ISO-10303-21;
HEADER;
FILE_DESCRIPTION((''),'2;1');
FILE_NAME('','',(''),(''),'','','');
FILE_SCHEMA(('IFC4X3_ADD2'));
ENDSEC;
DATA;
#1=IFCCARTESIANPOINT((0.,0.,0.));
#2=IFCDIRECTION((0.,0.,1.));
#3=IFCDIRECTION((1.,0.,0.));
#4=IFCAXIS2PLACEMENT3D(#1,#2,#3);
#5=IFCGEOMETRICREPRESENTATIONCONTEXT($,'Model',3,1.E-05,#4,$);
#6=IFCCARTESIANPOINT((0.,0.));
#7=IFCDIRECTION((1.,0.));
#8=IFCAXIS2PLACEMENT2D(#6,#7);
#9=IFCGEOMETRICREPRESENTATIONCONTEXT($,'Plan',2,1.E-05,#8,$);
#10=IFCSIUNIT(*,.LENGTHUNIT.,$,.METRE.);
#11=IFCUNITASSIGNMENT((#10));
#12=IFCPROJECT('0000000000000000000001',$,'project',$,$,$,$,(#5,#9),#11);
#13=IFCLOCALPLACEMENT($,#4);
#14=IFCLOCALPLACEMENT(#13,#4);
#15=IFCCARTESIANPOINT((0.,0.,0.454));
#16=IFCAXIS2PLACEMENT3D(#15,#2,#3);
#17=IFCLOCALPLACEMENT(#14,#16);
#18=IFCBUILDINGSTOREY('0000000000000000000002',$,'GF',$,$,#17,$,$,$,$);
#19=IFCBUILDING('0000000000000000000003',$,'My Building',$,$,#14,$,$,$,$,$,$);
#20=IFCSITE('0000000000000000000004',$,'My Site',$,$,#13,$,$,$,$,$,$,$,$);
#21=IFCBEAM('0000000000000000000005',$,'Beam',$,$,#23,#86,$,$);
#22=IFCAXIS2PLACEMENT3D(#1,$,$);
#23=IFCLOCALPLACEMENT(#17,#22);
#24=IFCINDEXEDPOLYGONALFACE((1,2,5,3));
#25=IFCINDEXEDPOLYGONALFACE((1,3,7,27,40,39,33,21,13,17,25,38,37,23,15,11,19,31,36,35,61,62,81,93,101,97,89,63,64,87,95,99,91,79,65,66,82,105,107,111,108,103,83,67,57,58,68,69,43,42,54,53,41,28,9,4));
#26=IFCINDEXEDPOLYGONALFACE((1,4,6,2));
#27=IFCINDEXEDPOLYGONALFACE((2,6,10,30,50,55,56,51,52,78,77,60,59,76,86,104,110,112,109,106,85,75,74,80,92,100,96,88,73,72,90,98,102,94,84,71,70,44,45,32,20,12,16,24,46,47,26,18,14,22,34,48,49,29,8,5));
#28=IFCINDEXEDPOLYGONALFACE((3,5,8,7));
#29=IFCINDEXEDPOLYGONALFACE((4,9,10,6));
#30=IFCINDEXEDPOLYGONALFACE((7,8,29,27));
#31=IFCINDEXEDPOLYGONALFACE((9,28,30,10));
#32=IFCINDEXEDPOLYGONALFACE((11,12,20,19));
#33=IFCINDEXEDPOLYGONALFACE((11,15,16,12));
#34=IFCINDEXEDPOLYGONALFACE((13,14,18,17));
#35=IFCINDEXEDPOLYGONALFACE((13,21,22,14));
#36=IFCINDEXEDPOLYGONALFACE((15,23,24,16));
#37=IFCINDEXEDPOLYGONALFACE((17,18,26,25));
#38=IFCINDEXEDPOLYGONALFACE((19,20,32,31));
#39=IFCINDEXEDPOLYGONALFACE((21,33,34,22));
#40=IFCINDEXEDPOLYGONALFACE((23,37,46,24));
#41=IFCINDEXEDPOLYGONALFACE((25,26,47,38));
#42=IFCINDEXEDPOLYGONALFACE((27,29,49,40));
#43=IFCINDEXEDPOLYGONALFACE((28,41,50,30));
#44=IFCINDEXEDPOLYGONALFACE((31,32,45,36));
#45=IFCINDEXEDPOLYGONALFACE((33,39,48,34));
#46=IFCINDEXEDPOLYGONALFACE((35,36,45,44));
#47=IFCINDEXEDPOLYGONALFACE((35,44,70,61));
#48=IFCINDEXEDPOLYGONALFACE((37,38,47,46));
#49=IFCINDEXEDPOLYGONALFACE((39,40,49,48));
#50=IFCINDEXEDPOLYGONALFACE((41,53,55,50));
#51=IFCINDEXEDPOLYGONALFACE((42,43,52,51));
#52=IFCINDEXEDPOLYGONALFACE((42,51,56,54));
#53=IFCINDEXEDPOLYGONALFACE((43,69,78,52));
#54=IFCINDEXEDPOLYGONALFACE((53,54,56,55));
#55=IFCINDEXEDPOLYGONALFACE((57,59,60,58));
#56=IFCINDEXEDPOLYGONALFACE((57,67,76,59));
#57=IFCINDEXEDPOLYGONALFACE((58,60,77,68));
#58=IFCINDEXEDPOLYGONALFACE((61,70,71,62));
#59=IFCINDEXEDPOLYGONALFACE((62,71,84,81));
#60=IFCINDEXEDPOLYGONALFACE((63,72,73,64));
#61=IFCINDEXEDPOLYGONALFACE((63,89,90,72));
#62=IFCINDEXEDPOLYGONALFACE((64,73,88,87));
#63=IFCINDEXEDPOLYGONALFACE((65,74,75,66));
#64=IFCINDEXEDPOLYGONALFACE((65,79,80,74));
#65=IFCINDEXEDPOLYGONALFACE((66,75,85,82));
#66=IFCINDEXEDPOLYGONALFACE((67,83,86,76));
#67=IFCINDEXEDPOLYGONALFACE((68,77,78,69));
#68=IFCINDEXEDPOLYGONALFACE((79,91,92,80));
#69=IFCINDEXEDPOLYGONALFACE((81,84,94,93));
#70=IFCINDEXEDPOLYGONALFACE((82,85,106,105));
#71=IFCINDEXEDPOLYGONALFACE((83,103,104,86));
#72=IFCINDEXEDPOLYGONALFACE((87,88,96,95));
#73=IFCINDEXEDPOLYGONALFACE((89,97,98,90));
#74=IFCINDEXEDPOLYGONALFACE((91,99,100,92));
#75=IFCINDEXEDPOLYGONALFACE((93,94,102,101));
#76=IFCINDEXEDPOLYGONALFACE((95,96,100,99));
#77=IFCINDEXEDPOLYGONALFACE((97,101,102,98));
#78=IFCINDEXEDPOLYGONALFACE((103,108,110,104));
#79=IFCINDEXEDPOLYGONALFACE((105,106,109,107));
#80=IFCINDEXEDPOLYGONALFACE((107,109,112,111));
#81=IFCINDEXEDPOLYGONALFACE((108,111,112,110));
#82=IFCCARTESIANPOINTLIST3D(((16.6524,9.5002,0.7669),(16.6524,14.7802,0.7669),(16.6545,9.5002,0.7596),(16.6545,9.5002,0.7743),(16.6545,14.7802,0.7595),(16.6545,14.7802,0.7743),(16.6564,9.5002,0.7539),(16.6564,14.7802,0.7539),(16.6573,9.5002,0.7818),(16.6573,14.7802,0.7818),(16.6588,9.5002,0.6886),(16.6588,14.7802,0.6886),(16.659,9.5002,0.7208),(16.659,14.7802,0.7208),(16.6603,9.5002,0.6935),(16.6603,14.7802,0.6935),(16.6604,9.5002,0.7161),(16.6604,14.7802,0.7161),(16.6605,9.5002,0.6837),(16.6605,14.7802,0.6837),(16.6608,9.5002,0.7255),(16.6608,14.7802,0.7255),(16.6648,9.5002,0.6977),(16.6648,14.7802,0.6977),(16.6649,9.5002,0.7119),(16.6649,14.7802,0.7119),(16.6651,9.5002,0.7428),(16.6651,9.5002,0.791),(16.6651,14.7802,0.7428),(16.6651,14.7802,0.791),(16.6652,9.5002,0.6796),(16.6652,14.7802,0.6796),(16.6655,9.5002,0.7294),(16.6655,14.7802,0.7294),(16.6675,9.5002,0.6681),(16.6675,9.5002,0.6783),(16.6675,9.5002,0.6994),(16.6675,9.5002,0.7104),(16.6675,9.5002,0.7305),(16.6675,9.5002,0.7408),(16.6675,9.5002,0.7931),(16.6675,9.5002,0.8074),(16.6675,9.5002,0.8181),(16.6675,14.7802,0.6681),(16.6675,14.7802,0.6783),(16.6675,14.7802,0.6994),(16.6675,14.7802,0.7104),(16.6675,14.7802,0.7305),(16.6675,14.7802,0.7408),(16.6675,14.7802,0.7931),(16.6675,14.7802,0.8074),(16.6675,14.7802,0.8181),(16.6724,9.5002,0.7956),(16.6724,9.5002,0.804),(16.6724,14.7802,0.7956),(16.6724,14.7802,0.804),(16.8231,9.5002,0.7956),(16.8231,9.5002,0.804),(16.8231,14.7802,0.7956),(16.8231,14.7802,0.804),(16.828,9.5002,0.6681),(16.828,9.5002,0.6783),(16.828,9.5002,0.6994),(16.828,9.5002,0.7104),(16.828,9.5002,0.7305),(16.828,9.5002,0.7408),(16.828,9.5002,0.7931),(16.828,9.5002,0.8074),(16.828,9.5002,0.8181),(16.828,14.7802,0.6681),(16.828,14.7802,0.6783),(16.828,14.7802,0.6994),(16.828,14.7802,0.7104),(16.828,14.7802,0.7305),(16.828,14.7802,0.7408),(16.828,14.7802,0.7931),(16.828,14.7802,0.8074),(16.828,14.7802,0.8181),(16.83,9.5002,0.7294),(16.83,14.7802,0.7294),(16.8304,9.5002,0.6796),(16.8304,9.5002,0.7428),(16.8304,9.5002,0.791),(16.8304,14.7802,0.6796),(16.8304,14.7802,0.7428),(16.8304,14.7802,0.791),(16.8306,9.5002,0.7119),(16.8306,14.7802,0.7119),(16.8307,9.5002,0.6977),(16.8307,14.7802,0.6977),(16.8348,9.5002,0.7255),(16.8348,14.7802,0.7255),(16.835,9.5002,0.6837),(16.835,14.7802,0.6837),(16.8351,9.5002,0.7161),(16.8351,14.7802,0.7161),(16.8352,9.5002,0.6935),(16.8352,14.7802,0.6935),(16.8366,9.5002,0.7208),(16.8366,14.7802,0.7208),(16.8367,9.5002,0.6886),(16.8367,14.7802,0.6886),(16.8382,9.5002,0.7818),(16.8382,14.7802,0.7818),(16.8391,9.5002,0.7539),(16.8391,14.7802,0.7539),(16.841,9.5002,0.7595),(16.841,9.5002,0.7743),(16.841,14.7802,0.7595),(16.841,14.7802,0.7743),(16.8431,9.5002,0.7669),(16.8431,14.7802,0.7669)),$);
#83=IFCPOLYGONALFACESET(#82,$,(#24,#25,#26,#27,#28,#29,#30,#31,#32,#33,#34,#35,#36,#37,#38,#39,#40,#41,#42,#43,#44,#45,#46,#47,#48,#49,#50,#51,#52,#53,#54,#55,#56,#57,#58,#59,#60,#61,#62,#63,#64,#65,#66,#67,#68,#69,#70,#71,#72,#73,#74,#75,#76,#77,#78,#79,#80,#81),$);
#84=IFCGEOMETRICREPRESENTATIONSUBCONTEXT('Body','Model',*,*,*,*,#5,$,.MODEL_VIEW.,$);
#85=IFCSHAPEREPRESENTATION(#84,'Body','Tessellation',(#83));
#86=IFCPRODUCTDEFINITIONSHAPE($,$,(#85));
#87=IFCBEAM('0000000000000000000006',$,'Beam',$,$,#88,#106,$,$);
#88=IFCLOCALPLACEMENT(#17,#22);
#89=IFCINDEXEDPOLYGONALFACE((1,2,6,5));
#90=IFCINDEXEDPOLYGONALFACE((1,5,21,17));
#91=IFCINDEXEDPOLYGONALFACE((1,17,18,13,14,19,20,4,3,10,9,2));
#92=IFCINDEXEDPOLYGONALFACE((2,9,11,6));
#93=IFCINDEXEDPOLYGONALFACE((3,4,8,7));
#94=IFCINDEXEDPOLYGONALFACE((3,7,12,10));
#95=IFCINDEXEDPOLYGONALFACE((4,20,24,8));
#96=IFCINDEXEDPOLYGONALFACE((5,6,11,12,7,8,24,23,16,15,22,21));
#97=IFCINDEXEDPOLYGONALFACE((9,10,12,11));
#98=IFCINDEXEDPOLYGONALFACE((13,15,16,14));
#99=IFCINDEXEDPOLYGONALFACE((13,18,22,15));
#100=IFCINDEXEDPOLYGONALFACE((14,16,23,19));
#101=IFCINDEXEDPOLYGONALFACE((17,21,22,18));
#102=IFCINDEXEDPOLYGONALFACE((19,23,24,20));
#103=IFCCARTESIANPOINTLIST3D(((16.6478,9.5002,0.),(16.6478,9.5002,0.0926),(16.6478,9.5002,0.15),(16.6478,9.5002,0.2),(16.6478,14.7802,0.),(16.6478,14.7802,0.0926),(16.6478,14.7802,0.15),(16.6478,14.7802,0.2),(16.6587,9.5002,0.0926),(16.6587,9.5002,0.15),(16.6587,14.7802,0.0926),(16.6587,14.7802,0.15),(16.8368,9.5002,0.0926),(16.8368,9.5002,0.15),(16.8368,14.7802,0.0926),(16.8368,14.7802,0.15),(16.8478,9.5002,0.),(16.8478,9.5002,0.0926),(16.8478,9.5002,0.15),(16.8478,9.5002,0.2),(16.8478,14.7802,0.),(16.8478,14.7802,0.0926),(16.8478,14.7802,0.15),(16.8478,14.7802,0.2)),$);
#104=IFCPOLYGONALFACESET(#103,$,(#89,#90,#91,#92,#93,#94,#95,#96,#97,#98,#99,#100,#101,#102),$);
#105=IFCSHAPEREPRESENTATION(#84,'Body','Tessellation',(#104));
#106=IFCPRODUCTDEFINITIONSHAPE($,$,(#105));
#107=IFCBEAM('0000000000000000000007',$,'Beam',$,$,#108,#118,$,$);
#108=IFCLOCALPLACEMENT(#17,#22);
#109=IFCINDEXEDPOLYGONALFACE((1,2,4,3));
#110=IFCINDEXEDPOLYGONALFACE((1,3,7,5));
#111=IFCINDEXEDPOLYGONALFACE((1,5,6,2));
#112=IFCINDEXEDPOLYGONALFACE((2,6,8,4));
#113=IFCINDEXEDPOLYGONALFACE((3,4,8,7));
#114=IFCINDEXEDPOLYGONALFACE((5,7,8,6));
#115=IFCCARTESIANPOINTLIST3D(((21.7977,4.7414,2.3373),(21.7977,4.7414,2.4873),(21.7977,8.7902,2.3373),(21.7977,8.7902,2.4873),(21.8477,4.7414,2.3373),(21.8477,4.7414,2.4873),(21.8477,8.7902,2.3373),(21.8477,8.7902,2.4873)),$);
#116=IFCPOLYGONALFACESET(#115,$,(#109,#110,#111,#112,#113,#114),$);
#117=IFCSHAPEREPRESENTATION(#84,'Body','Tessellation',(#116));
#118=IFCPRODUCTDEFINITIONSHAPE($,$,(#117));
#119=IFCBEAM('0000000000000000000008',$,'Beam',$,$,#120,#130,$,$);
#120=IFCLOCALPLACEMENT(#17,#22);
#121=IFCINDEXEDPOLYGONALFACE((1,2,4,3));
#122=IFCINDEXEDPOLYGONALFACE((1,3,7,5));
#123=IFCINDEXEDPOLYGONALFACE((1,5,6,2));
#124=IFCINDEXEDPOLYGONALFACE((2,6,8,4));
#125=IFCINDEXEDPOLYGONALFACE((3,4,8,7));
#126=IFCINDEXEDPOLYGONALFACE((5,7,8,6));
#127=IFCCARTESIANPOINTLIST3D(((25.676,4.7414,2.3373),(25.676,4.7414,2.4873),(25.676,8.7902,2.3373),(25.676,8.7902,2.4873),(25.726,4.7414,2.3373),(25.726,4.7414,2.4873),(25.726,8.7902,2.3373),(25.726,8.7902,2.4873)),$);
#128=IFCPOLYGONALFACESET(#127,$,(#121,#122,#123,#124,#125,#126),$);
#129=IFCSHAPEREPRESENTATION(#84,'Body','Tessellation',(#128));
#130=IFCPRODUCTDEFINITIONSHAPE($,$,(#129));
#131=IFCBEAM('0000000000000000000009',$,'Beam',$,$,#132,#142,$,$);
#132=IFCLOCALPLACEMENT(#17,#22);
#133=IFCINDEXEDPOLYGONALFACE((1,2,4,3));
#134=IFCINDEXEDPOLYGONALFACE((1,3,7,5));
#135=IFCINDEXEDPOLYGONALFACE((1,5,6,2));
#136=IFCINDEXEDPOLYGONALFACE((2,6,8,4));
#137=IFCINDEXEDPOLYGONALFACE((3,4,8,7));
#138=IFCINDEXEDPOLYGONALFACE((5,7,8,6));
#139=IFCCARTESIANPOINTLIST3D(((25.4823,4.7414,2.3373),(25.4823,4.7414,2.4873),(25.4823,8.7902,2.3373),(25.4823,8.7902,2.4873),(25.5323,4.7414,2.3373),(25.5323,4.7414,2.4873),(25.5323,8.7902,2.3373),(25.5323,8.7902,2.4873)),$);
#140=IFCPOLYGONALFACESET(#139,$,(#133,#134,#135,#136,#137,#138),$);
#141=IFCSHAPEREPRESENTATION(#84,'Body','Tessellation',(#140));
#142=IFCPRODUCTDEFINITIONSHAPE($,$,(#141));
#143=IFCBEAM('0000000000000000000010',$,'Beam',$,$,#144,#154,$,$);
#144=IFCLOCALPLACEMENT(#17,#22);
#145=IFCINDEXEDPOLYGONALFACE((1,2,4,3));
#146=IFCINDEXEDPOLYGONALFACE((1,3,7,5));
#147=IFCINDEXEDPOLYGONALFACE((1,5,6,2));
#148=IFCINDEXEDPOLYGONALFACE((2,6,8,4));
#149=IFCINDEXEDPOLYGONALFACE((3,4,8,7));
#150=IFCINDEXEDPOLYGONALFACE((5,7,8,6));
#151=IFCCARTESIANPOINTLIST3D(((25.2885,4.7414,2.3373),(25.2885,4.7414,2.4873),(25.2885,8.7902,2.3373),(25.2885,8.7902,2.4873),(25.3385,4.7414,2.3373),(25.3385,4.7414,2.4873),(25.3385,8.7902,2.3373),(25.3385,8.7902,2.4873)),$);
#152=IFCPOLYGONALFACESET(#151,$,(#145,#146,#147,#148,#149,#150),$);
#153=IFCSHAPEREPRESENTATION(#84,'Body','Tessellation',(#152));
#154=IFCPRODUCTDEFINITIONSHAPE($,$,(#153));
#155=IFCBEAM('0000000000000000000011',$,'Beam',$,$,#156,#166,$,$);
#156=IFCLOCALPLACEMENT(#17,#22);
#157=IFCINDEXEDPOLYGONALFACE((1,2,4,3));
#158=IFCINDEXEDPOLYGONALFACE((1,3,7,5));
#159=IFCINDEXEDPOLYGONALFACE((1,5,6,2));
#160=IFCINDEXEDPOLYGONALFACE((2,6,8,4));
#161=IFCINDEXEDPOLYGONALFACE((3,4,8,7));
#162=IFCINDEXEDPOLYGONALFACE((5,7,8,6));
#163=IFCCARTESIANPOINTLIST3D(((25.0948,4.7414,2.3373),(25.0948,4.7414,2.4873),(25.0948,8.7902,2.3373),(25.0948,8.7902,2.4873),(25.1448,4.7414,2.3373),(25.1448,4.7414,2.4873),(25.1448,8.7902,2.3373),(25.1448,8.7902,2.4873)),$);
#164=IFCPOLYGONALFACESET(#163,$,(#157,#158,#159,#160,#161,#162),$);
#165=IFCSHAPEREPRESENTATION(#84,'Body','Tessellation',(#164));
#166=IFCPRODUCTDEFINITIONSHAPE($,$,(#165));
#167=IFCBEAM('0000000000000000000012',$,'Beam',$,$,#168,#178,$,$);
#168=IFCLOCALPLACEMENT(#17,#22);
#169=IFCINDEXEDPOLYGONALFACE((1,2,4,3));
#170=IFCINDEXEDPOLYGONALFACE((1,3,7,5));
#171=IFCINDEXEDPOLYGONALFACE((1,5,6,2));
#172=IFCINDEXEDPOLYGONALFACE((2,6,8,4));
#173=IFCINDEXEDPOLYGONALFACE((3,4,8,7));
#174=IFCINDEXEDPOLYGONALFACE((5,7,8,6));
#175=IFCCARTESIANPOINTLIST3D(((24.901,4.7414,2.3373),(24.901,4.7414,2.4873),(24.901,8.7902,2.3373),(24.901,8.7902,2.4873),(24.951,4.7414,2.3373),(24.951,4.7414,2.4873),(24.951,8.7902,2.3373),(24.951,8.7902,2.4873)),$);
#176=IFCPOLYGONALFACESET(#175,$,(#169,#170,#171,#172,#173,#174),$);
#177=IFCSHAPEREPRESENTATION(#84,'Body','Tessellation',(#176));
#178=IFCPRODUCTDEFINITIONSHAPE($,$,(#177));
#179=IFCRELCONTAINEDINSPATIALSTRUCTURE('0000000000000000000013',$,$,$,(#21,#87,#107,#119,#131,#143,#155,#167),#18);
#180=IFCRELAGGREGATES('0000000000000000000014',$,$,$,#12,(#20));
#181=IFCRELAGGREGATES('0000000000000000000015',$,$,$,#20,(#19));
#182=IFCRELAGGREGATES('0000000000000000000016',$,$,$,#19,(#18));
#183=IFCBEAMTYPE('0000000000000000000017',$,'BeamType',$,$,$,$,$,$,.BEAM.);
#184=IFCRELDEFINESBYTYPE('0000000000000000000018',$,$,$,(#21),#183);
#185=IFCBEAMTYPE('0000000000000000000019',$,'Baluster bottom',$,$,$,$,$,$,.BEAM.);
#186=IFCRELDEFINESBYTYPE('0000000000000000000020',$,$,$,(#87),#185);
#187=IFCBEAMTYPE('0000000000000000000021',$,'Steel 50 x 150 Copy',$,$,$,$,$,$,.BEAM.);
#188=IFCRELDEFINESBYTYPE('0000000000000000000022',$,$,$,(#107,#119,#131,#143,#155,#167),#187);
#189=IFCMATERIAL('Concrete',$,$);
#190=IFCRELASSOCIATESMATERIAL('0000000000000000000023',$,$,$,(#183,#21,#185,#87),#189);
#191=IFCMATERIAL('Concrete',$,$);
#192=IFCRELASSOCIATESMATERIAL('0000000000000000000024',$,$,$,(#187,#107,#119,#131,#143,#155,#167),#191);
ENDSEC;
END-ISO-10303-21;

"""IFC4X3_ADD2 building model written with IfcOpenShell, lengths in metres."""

from ifc_helpers import new_model, si_unit, frame, origin_with_axes, origin_2d_with_axis, place, context, subcontext, project, spatial, indexed_curve, rectangle, outline, extrude, material, material_profile, profile_set, profile_usage, type_object, element, save


model = new_model("IFC4X3_ADD2")

# Units and contexts
model_context = context("Model", 3, precision=1e-05, world=origin_with_axes())
plan_context = context("Plan", 2, precision=1e-05, world=origin_2d_with_axis())
body_context = subcontext(model_context, "Body", "Model", "MODEL_VIEW")
ifc_project = project(units=[si_unit("LENGTHUNIT", "METRE")], contexts=[model_context, plan_context])

# Site, building, storey
site_placement = place(None, origin_with_axes())
site = spatial("IfcSite", under=ifc_project, at=site_placement, Name="My Site")
building_placement = place(site_placement, origin_with_axes())
building = spatial("IfcBuilding", under=site, at=building_placement, Name="My Building")
storey_placement = place(building_placement, frame((0.0, 0.0, 0.454), z_axis=(0.0, 0.0, 1.0), x_axis=(1.0, 0.0, 0.0)))
storey = spatial("IfcBuildingStorey", under=building, at=storey_placement, Name="GF")

# Beams
ifc_material_1 = material(Name="Concrete")
ifc_material_profile_1 = material_profile(ifc_material_1, outline(indexed_curve([(0.0803, 0.0102), (0.0826, 0.0116), (0.0872, 0.0156), (0.0889, 0.0205), (0.0874, 0.0254), (0.083, 0.0297), (0.0803, 0.0314), (0.0803, 0.0423), (0.0828, 0.0439), (0.0873, 0.048), (0.0888, 0.0528), (0.087, 0.0574), (0.0822, 0.0613), (0.0803, 0.0624), (0.0803, 0.0727), (0.0827, 0.0747), (0.0914, 0.0858), (0.0933, 0.0915), (0.0953, 0.0989), (0.0933, 0.1062), (0.0904, 0.1137), (0.0827, 0.123), (0.0803, 0.125), (0.0754, 0.1276), (0.0754, 0.1359), (0.0803, 0.1393), (0.0803, 0.15), (-0.0803, 0.15), (-0.0803, 0.1393), (-0.0754, 0.1359), (-0.0754, 0.1276), (-0.0803, 0.125), (-0.0827, 0.123), (-0.0904, 0.1137), (-0.0933, 0.1062), (-0.0953, 0.0989), (-0.0933, 0.0915), (-0.0914, 0.0858), (-0.0827, 0.0747), (-0.0803, 0.0727), (-0.0803, 0.0624), (-0.0822, 0.0613), (-0.087, 0.0574), (-0.0888, 0.0528), (-0.0873, 0.048), (-0.0828, 0.0439), (-0.0803, 0.0423), (-0.0803, 0.0314), (-0.083, 0.0297), (-0.0874, 0.0254), (-0.0889, 0.0205), (-0.0872, 0.0157), (-0.0826, 0.0116), (-0.0803, 0.0102), (-0.0803, 0.0), (0.0803, 0.0), (0.0803, 0.0102)])))
ifc_profile_set_1 = profile_set([ifc_material_profile_1])
ifc_profile_usage_1 = profile_usage(ifc_profile_set_1, cardinal=5)
beam_type_1 = type_object("IfcBeamType", Name="BeamType", PredefinedType="BEAM", material=ifc_profile_set_1)
beam_1_placement = place(storey_placement, frame((16.7478, 14.7802, 0.6681), z_axis=(0.0, -1.0, 0.0), x_axis=(1.0, 0.0, 0.0)))
element("IfcBeam", 1, at=beam_1_placement, inside=storey, type_object=beam_type_1, material=ifc_profile_usage_1, Name="Beam", context=body_context, shape_type="SweptSolid", body=[
    extrude(outline(indexed_curve([(0.0803, 0.0102), (0.0826, 0.0116), (0.0872, 0.0156), (0.0889, 0.0205), (0.0874, 0.0254), (0.083, 0.0297), (0.0803, 0.0314), (0.0803, 0.0423), (0.0828, 0.0439), (0.0873, 0.048), (0.0888, 0.0528), (0.087, 0.0574), (0.0822, 0.0613), (0.0803, 0.0624), (0.0803, 0.0727), (0.0827, 0.0747), (0.0914, 0.0858), (0.0933, 0.0915), (0.0953, 0.0989), (0.0933, 0.1062), (0.0904, 0.1137), (0.0827, 0.123), (0.0803, 0.125), (0.0754, 0.1276), (0.0754, 0.1359), (0.0803, 0.1393), (0.0803, 0.15), (-0.0803, 0.15), (-0.0803, 0.1393), (-0.0754, 0.1359), (-0.0754, 0.1276), (-0.0803, 0.125), (-0.0827, 0.123), (-0.0904, 0.1137), (-0.0933, 0.1062), (-0.0953, 0.0989), (-0.0933, 0.0915), (-0.0914, 0.0858), (-0.0827, 0.0747), (-0.0803, 0.0727), (-0.0803, 0.0624), (-0.0822, 0.0613), (-0.087, 0.0574), (-0.0888, 0.0528), (-0.0873, 0.048), (-0.0828, 0.0439), (-0.0803, 0.0423), (-0.0803, 0.0314), (-0.083, 0.0297), (-0.0874, 0.0254), (-0.0889, 0.0205), (-0.0872, 0.0157), (-0.0826, 0.0116), (-0.0803, 0.0102), (-0.0803, 0.0), (0.0803, 0.0), (0.0803, 0.0102)])), origin_with_axes(), (0.0, 0.0, 1.0), 5.28),
])
ifc_material_profile_2 = material_profile(ifc_material_1, outline(indexed_curve([(0.0891, 0.15), (0.1, 0.15), (0.1, 0.2), (-0.1, 0.2), (-0.1, 0.15), (-0.0891, 0.15), (-0.0891, 0.0926), (-0.1, 0.0926), (-0.1, 0.0), (0.1, 0.0), (0.1, 0.0926), (0.0891, 0.0926), (0.0891, 0.15)])))
ifc_profile_set_2 = profile_set([ifc_material_profile_2])
ifc_profile_usage_2 = profile_usage(ifc_profile_set_2, cardinal=5)
beam_type_2 = type_object("IfcBeamType", Name="Baluster bottom", PredefinedType="BEAM", material=ifc_profile_set_2)
beam_2_placement = place(storey_placement, frame((16.7478, 14.7802, 0.0), z_axis=(0.0, -1.0, 0.0), x_axis=(1.0, 0.0, 0.0)))
element("IfcBeam", 2, at=beam_2_placement, inside=storey, type_object=beam_type_2, material=ifc_profile_usage_2, Name="Beam", context=body_context, shape_type="SweptSolid", body=[
    extrude(outline(indexed_curve([(0.0891, 0.15), (0.1, 0.15), (0.1, 0.2), (-0.1, 0.2), (-0.1, 0.15), (-0.0891, 0.15), (-0.0891, 0.0926), (-0.1, 0.0926), (-0.1, 0.0), (0.1, 0.0), (0.1, 0.0926), (0.0891, 0.0926), (0.0891, 0.15)])), origin_with_axes(), (0.0, 0.0, 1.0), 5.28),
])
ifc_material_2 = material(Name="Concrete")
ifc_material_profile_3 = material_profile(ifc_material_2, rectangle(XDim=0.05, YDim=0.15))
ifc_profile_set_3 = profile_set([ifc_material_profile_3])
ifc_profile_usage_3 = profile_usage(ifc_profile_set_3)
beam_type_3 = type_object("IfcBeamType", Name="Steel 50 x 150 Copy", PredefinedType="BEAM", material=ifc_profile_set_3)
beam_3_placement = place(storey_placement, frame((21.8227, 8.7902, 2.4123), z_axis=(0.0, -1.0, 0.0), x_axis=(1.0, 0.0, 0.0)))
element("IfcBeam", 3, at=beam_3_placement, inside=storey, type_object=beam_type_3, material=ifc_profile_usage_3, Name="Beam", context=body_context, shape_type="SweptSolid", body=[
    extrude(rectangle(XDim=0.05, YDim=0.15), origin_with_axes(), (0.0, 0.0, 1.0), 4.0488),
])
ifc_profile_usage_4 = profile_usage(ifc_profile_set_3)
beam_4_placement = place(storey_placement, frame((25.701, 8.7902, 2.4123), z_axis=(0.0, -1.0, 0.0), x_axis=(1.0, 0.0, 0.0)))
element("IfcBeam", 4, at=beam_4_placement, inside=storey, type_object=beam_type_3, material=ifc_profile_usage_4, Name="Beam", context=body_context, shape_type="SweptSolid", body=[
    extrude(rectangle(XDim=0.05, YDim=0.15), origin_with_axes(), (0.0, 0.0, 1.0), 4.0488),
])
ifc_profile_usage_5 = profile_usage(ifc_profile_set_3)
beam_5_placement = place(storey_placement, frame((25.5073, 8.7902, 2.4123), z_axis=(0.0, -1.0, 0.0), x_axis=(1.0, 0.0, 0.0)))
element("IfcBeam", 5, at=beam_5_placement, inside=storey, type_object=beam_type_3, material=ifc_profile_usage_5, Name="Beam", context=body_context, shape_type="SweptSolid", body=[
    extrude(rectangle(XDim=0.05, YDim=0.15), origin_with_axes(), (0.0, 0.0, 1.0), 4.0488),
])
ifc_profile_usage_6 = profile_usage(ifc_profile_set_3)
beam_6_placement = place(storey_placement, frame((25.3135, 8.7902, 2.4123), z_axis=(0.0, -1.0, 0.0), x_axis=(1.0, 0.0, 0.0)))
element("IfcBeam", 6, at=beam_6_placement, inside=storey, type_object=beam_type_3, material=ifc_profile_usage_6, Name="Beam", context=body_context, shape_type="SweptSolid", body=[
    extrude(rectangle(XDim=0.05, YDim=0.15), origin_with_axes(), (0.0, 0.0, 1.0), 4.0488),
])
ifc_profile_usage_7 = profile_usage(ifc_profile_set_3)
beam_7_placement = place(storey_placement, frame((25.1198, 8.7902, 2.4123), z_axis=(0.0, -1.0, 0.0), x_axis=(1.0, 0.0, 0.0)))
element("IfcBeam", 7, at=beam_7_placement, inside=storey, type_object=beam_type_3, material=ifc_profile_usage_7, Name="Beam", context=body_context, shape_type="SweptSolid", body=[
    extrude(rectangle(XDim=0.05, YDim=0.15), origin_with_axes(), (0.0, 0.0, 1.0), 4.0488),
])
ifc_profile_usage_8 = profile_usage(ifc_profile_set_3)
beam_8_placement = place(storey_placement, frame((24.926, 8.7902, 2.4123), z_axis=(0.0, -1.0, 0.0), x_axis=(1.0, 0.0, 0.0)))
element("IfcBeam", 8, at=beam_8_placement, inside=storey, type_object=beam_type_3, material=ifc_profile_usage_8, Name="Beam", context=body_context, shape_type="SweptSolid", body=[
    extrude(rectangle(XDim=0.05, YDim=0.15), origin_with_axes(), (0.0, 0.0, 1.0), 4.0488),
])

save(model, "model.ifc")
